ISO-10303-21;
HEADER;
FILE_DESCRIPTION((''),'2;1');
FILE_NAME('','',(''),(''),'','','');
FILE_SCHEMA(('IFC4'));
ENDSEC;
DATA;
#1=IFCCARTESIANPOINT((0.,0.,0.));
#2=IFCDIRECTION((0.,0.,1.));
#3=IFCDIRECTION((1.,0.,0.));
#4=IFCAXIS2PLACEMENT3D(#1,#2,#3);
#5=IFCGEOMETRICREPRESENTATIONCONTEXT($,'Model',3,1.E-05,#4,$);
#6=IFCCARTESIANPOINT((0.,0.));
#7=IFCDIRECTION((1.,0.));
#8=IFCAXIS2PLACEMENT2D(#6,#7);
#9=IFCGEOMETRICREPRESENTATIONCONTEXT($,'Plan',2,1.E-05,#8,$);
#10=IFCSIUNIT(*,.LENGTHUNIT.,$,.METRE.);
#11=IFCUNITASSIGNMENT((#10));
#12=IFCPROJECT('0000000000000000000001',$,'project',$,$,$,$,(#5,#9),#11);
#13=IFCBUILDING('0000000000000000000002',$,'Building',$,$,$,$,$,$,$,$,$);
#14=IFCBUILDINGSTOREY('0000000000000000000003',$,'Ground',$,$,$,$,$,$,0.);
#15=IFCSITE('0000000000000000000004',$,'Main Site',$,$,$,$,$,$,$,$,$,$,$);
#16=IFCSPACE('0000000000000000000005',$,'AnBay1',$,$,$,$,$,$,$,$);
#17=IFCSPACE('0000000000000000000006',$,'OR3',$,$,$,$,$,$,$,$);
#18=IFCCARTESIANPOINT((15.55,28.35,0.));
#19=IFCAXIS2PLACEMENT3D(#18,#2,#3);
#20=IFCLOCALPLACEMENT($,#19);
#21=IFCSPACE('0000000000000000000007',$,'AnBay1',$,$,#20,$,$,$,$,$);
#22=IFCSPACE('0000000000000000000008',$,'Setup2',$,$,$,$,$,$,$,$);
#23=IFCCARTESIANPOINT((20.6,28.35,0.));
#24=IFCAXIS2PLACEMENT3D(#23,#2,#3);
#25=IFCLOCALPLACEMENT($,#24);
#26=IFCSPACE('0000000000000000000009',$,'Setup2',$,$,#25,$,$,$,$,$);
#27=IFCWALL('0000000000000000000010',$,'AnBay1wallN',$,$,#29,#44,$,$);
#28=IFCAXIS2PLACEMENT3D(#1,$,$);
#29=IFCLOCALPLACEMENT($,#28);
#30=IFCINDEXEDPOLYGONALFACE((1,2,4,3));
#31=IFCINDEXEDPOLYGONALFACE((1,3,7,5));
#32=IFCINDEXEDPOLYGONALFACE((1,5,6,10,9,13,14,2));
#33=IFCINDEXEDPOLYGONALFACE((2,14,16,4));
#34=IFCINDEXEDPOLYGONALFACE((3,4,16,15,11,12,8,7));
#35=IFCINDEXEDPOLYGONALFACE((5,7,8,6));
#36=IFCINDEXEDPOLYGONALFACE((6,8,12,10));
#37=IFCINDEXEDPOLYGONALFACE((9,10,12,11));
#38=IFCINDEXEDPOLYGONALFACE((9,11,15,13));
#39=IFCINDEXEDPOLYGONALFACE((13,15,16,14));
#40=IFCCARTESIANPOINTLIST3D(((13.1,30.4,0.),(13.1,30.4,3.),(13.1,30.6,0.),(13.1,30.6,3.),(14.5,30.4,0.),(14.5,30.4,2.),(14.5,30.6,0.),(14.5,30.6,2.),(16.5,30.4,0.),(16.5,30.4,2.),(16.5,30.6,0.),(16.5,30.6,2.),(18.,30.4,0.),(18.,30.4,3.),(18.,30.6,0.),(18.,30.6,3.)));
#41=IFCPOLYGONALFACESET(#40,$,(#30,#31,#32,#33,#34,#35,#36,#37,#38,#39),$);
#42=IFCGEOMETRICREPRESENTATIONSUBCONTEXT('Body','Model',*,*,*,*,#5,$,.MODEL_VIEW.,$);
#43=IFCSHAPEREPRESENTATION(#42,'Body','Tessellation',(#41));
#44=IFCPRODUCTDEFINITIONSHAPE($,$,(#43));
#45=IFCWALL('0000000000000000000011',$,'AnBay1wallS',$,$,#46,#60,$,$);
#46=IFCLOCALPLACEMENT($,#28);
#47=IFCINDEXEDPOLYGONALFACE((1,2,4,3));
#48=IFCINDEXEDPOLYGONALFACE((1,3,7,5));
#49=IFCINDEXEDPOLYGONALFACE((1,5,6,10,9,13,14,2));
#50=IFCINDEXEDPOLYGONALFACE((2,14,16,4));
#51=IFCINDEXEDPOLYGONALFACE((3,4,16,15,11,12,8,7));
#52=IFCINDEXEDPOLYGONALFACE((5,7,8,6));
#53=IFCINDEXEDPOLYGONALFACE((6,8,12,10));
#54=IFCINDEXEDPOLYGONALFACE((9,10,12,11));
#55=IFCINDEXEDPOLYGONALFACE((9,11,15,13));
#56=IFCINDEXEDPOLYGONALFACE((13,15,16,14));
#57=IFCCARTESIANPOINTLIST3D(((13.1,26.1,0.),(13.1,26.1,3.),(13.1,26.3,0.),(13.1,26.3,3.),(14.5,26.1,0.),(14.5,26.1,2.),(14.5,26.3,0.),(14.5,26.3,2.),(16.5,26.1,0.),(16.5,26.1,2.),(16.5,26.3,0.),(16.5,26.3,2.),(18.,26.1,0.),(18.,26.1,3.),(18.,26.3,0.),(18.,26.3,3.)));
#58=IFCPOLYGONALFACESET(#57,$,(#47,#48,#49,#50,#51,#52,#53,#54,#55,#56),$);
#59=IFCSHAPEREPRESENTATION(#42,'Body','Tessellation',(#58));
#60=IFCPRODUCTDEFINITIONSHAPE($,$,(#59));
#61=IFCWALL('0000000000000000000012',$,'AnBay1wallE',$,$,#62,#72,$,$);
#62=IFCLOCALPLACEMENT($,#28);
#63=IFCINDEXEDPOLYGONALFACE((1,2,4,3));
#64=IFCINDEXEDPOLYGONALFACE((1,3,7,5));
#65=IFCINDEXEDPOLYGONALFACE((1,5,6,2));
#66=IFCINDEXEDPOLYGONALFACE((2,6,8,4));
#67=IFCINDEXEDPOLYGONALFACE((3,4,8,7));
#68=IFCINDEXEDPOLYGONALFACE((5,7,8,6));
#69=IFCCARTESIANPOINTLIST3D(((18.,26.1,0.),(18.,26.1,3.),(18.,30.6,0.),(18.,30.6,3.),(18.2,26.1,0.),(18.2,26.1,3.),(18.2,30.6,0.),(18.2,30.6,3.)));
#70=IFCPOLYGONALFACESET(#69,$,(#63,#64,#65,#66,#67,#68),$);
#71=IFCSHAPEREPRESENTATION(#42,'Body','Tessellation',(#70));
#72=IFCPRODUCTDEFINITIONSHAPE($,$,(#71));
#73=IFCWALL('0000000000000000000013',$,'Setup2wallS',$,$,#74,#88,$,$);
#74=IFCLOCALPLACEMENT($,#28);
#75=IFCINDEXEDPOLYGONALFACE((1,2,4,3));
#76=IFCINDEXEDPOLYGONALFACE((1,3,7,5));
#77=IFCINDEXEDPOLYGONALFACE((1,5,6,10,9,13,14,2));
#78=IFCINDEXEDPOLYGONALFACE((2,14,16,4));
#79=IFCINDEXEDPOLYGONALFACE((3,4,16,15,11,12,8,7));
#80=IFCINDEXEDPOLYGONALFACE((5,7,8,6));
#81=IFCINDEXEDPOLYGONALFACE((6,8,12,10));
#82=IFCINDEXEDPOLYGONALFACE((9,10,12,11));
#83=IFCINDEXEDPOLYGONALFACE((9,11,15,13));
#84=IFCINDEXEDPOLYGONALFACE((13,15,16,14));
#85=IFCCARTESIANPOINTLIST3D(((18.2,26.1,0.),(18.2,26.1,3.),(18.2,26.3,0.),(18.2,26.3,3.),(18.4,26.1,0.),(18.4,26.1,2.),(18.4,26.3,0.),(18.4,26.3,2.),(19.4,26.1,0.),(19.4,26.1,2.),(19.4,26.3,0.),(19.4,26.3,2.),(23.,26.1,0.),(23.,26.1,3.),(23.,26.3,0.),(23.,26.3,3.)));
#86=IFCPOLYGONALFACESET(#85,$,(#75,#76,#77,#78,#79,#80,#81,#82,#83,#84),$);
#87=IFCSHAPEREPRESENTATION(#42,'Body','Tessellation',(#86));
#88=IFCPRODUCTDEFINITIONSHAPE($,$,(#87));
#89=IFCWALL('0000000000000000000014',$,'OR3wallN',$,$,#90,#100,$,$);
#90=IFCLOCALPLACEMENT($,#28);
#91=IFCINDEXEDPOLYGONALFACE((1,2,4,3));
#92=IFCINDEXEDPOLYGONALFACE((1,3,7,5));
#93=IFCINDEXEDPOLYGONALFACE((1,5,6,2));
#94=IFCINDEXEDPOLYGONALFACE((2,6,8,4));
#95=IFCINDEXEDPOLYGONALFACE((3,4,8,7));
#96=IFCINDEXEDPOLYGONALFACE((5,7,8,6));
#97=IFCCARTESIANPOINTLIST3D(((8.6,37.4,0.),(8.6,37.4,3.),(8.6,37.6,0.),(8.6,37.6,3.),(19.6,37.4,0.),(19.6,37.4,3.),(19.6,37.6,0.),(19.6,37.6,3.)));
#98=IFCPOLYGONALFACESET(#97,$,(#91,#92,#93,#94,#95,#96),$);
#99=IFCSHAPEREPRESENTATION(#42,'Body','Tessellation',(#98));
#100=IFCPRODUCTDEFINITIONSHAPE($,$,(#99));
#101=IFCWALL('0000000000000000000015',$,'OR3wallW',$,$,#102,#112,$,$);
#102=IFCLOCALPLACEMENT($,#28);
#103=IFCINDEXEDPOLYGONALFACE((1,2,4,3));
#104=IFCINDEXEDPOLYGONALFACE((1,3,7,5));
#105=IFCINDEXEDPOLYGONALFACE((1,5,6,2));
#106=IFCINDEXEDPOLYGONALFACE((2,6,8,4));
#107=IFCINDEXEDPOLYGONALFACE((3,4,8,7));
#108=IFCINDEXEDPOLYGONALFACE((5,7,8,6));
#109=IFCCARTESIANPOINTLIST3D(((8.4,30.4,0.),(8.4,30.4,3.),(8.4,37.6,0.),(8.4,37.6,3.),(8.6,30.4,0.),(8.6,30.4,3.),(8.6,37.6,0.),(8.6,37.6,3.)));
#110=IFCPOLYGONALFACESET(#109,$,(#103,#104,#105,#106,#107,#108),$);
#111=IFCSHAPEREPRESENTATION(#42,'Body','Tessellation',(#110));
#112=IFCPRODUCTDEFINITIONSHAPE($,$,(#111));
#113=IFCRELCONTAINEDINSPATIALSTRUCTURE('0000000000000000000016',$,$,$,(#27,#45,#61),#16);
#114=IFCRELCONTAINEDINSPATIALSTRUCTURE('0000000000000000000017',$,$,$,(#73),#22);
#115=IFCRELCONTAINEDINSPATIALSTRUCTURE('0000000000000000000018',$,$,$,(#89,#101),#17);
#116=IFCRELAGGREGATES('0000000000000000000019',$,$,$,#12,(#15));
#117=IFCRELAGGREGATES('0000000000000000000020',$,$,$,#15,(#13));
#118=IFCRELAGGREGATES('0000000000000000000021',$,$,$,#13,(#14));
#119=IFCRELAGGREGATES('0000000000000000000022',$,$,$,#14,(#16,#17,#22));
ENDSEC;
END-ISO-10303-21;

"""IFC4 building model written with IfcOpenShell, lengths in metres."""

from ifc_helpers import new_model, si_unit, frame, origin_with_axes, origin_2d_with_axis, place, context, subcontext, project, spatial, indexed_curve, outline, extrude, element, save


model = new_model("IFC4")

# Units and contexts
model_context = context("Model", 3, precision=1e-05, world=origin_with_axes())
plan_context = context("Plan", 2, precision=1e-05, world=origin_2d_with_axis())
body_context = subcontext(model_context, "Body", "Model", "MODEL_VIEW")
ifc_project = project(units=[si_unit("LENGTHUNIT", "METRE")], contexts=[model_context, plan_context])

# Site, building, storey
site = spatial("IfcSite", under=ifc_project, Name="Main Site")
building = spatial("IfcBuilding", under=site, Name="Building")
storey = spatial("IfcBuildingStorey", under=building, Name="Ground", Elevation=0.0)

# Shared definitions
space_1 = spatial("IfcSpace", under=storey, Name="AnBay1")

# Shared definitions
space_2 = spatial("IfcSpace", under=storey, Name="OR3")

# Wall
wall_1_placement = place(None, frame((13.1, 30.4, 0.0), z_axis=(0.0, 0.0, 1.0), x_axis=(1.0, 0.0, 0.0)))
wall_1 = element("IfcWall", 1, at=wall_1_placement, inside=space_1, Name="AnBay1wallN", context=body_context, shape_type="SweptSolid", body=[
    extrude(outline(indexed_curve([(0.0, 0.0), (0.0, 0.2), (4.9, 0.2), (4.9, 0.0), (0.0, 0.0)], self_intersect=False)), origin_with_axes(), (0.0, 0.0, 1.0), 3.0),
])

# Shared definitions
space_3_placement = place(None, frame((15.55, 28.35, 0.0), z_axis=(0.0, 0.0, 1.0), x_axis=(1.0, 0.0, 0.0)))
space_3 = spatial("IfcSpace", at=space_3_placement, Name="AnBay1")

# Opening
opening_1_placement = place(wall_1_placement, frame((1.4, 0.0, 0.0), z_axis=(0.0, 0.0, 1.0), x_axis=(1.0, 0.0, 0.0)))
element("IfcOpeningElement", 2, at=opening_1_placement, inside=space_3, cuts=wall_1, context=body_context, shape_type="SweptSolid", body=[
    extrude(outline(indexed_curve([(0.0, 0.0), (0.0, 0.4), (2.0, 0.4), (2.0, 0.0), (0.0, 0.0)], self_intersect=False)), origin_with_axes(), (0.0, 0.0, 1.0), 2.0),
])

# Wall, opening
wall_2_placement = place(None, frame((13.1, 26.1, 0.0), z_axis=(0.0, 0.0, 1.0), x_axis=(1.0, 0.0, 0.0)))
wall_2 = element("IfcWall", 3, at=wall_2_placement, inside=space_1, Name="AnBay1wallS", context=body_context, shape_type="SweptSolid", body=[
    extrude(outline(indexed_curve([(0.0, 0.0), (0.0, 0.2), (4.9, 0.2), (4.9, 0.0), (0.0, 0.0)], self_intersect=False)), origin_with_axes(), (0.0, 0.0, 1.0), 3.0),
])
opening_2_placement = place(wall_2_placement, frame((1.4, 0.0, 0.0), z_axis=(0.0, 0.0, 1.0), x_axis=(1.0, 0.0, 0.0)))
element("IfcOpeningElement", 4, at=opening_2_placement, inside=space_3, cuts=wall_2, context=body_context, shape_type="SweptSolid", body=[
    extrude(outline(indexed_curve([(0.0, 0.0), (0.0, 0.4), (2.0, 0.4), (2.0, 0.0), (0.0, 0.0)], self_intersect=False)), origin_with_axes(), (0.0, 0.0, 1.0), 2.0),
])

# Wall
for number, where, z_axis, x_axis, name in (
    (5, (18.2, 26.1, 0.0), (0.0, 0.0, 1.0), (0.0, 1.0, 0.0), "AnBay1wallE"),
):
    element("IfcWall", number, at=place(None, frame(where, z_axis=z_axis, x_axis=x_axis)), inside=space_1, Name=name, context=body_context, shape_type="SweptSolid", body=[
        extrude(outline(indexed_curve([(0.0, 0.0), (0.0, 0.2), (4.5, 0.2), (4.5, 0.0), (0.0, 0.0)], self_intersect=False)), origin_with_axes(), (0.0, 0.0, 1.0), 3.0),
    ])

# Shared definitions
space_4 = spatial("IfcSpace", under=storey, Name="Setup2")

# Wall
wall_3_placement = place(None, frame((18.2, 26.1, 0.0), z_axis=(0.0, 0.0, 1.0), x_axis=(1.0, 0.0, 0.0)))
wall_3 = element("IfcWall", 6, at=wall_3_placement, inside=space_4, Name="Setup2wallS", context=body_context, shape_type="SweptSolid", body=[
    extrude(outline(indexed_curve([(0.0, 0.0), (0.0, 0.2), (4.8, 0.2), (4.8, 0.0), (0.0, 0.0)], self_intersect=False)), origin_with_axes(), (0.0, 0.0, 1.0), 3.0),
])

# Shared definitions
space_5_placement = place(None, frame((20.6, 28.35, 0.0), z_axis=(0.0, 0.0, 1.0), x_axis=(1.0, 0.0, 0.0)))
space_5 = spatial("IfcSpace", at=space_5_placement, Name="Setup2")

# Opening
opening_3_placement = place(wall_3_placement, frame((0.2, 0.0, 0.0), z_axis=(0.0, 0.0, 1.0), x_axis=(1.0, 0.0, 0.0)))
element("IfcOpeningElement", 7, at=opening_3_placement, inside=space_5, cuts=wall_3, context=body_context, shape_type="SweptSolid", body=[
    extrude(outline(indexed_curve([(0.0, 0.0), (0.0, 0.4), (1.0, 0.4), (1.0, 0.0), (0.0, 0.0)], self_intersect=False)), origin_with_axes(), (0.0, 0.0, 1.0), 2.0),
])

# Wall
wall_4_placement = place(None, frame((8.6, 37.4, 0.0), z_axis=(0.0, 0.0, 1.0), x_axis=(1.0, 0.0, 0.0)))
element("IfcWall", 8, at=wall_4_placement, inside=space_2, Name="OR3wallN", context=body_context, shape_type="SweptSolid", body=[
    extrude(outline(indexed_curve([(0.0, 0.0), (0.0, 0.2), (11.0, 0.2), (11.0, 0.0), (0.0, 0.0)], self_intersect=False)), origin_with_axes(), (0.0, 0.0, 1.0), 3.0),
])

# Wall
wall_5_placement = place(None, frame((8.6, 30.4, 0.0), z_axis=(0.0, 0.0, 1.0), x_axis=(0.0, 1.0, 0.0)))
element("IfcWall", 9, at=wall_5_placement, inside=space_2, Name="OR3wallW", context=body_context, shape_type="SweptSolid", body=[
    extrude(outline(indexed_curve([(0.0, 0.0), (0.0, 0.2), (7.2, 0.2), (7.2, 0.0), (0.0, 0.0)], self_intersect=False)), origin_with_axes(), (0.0, 0.0, 1.0), 3.0),
])

save(model, "model.ifc")
